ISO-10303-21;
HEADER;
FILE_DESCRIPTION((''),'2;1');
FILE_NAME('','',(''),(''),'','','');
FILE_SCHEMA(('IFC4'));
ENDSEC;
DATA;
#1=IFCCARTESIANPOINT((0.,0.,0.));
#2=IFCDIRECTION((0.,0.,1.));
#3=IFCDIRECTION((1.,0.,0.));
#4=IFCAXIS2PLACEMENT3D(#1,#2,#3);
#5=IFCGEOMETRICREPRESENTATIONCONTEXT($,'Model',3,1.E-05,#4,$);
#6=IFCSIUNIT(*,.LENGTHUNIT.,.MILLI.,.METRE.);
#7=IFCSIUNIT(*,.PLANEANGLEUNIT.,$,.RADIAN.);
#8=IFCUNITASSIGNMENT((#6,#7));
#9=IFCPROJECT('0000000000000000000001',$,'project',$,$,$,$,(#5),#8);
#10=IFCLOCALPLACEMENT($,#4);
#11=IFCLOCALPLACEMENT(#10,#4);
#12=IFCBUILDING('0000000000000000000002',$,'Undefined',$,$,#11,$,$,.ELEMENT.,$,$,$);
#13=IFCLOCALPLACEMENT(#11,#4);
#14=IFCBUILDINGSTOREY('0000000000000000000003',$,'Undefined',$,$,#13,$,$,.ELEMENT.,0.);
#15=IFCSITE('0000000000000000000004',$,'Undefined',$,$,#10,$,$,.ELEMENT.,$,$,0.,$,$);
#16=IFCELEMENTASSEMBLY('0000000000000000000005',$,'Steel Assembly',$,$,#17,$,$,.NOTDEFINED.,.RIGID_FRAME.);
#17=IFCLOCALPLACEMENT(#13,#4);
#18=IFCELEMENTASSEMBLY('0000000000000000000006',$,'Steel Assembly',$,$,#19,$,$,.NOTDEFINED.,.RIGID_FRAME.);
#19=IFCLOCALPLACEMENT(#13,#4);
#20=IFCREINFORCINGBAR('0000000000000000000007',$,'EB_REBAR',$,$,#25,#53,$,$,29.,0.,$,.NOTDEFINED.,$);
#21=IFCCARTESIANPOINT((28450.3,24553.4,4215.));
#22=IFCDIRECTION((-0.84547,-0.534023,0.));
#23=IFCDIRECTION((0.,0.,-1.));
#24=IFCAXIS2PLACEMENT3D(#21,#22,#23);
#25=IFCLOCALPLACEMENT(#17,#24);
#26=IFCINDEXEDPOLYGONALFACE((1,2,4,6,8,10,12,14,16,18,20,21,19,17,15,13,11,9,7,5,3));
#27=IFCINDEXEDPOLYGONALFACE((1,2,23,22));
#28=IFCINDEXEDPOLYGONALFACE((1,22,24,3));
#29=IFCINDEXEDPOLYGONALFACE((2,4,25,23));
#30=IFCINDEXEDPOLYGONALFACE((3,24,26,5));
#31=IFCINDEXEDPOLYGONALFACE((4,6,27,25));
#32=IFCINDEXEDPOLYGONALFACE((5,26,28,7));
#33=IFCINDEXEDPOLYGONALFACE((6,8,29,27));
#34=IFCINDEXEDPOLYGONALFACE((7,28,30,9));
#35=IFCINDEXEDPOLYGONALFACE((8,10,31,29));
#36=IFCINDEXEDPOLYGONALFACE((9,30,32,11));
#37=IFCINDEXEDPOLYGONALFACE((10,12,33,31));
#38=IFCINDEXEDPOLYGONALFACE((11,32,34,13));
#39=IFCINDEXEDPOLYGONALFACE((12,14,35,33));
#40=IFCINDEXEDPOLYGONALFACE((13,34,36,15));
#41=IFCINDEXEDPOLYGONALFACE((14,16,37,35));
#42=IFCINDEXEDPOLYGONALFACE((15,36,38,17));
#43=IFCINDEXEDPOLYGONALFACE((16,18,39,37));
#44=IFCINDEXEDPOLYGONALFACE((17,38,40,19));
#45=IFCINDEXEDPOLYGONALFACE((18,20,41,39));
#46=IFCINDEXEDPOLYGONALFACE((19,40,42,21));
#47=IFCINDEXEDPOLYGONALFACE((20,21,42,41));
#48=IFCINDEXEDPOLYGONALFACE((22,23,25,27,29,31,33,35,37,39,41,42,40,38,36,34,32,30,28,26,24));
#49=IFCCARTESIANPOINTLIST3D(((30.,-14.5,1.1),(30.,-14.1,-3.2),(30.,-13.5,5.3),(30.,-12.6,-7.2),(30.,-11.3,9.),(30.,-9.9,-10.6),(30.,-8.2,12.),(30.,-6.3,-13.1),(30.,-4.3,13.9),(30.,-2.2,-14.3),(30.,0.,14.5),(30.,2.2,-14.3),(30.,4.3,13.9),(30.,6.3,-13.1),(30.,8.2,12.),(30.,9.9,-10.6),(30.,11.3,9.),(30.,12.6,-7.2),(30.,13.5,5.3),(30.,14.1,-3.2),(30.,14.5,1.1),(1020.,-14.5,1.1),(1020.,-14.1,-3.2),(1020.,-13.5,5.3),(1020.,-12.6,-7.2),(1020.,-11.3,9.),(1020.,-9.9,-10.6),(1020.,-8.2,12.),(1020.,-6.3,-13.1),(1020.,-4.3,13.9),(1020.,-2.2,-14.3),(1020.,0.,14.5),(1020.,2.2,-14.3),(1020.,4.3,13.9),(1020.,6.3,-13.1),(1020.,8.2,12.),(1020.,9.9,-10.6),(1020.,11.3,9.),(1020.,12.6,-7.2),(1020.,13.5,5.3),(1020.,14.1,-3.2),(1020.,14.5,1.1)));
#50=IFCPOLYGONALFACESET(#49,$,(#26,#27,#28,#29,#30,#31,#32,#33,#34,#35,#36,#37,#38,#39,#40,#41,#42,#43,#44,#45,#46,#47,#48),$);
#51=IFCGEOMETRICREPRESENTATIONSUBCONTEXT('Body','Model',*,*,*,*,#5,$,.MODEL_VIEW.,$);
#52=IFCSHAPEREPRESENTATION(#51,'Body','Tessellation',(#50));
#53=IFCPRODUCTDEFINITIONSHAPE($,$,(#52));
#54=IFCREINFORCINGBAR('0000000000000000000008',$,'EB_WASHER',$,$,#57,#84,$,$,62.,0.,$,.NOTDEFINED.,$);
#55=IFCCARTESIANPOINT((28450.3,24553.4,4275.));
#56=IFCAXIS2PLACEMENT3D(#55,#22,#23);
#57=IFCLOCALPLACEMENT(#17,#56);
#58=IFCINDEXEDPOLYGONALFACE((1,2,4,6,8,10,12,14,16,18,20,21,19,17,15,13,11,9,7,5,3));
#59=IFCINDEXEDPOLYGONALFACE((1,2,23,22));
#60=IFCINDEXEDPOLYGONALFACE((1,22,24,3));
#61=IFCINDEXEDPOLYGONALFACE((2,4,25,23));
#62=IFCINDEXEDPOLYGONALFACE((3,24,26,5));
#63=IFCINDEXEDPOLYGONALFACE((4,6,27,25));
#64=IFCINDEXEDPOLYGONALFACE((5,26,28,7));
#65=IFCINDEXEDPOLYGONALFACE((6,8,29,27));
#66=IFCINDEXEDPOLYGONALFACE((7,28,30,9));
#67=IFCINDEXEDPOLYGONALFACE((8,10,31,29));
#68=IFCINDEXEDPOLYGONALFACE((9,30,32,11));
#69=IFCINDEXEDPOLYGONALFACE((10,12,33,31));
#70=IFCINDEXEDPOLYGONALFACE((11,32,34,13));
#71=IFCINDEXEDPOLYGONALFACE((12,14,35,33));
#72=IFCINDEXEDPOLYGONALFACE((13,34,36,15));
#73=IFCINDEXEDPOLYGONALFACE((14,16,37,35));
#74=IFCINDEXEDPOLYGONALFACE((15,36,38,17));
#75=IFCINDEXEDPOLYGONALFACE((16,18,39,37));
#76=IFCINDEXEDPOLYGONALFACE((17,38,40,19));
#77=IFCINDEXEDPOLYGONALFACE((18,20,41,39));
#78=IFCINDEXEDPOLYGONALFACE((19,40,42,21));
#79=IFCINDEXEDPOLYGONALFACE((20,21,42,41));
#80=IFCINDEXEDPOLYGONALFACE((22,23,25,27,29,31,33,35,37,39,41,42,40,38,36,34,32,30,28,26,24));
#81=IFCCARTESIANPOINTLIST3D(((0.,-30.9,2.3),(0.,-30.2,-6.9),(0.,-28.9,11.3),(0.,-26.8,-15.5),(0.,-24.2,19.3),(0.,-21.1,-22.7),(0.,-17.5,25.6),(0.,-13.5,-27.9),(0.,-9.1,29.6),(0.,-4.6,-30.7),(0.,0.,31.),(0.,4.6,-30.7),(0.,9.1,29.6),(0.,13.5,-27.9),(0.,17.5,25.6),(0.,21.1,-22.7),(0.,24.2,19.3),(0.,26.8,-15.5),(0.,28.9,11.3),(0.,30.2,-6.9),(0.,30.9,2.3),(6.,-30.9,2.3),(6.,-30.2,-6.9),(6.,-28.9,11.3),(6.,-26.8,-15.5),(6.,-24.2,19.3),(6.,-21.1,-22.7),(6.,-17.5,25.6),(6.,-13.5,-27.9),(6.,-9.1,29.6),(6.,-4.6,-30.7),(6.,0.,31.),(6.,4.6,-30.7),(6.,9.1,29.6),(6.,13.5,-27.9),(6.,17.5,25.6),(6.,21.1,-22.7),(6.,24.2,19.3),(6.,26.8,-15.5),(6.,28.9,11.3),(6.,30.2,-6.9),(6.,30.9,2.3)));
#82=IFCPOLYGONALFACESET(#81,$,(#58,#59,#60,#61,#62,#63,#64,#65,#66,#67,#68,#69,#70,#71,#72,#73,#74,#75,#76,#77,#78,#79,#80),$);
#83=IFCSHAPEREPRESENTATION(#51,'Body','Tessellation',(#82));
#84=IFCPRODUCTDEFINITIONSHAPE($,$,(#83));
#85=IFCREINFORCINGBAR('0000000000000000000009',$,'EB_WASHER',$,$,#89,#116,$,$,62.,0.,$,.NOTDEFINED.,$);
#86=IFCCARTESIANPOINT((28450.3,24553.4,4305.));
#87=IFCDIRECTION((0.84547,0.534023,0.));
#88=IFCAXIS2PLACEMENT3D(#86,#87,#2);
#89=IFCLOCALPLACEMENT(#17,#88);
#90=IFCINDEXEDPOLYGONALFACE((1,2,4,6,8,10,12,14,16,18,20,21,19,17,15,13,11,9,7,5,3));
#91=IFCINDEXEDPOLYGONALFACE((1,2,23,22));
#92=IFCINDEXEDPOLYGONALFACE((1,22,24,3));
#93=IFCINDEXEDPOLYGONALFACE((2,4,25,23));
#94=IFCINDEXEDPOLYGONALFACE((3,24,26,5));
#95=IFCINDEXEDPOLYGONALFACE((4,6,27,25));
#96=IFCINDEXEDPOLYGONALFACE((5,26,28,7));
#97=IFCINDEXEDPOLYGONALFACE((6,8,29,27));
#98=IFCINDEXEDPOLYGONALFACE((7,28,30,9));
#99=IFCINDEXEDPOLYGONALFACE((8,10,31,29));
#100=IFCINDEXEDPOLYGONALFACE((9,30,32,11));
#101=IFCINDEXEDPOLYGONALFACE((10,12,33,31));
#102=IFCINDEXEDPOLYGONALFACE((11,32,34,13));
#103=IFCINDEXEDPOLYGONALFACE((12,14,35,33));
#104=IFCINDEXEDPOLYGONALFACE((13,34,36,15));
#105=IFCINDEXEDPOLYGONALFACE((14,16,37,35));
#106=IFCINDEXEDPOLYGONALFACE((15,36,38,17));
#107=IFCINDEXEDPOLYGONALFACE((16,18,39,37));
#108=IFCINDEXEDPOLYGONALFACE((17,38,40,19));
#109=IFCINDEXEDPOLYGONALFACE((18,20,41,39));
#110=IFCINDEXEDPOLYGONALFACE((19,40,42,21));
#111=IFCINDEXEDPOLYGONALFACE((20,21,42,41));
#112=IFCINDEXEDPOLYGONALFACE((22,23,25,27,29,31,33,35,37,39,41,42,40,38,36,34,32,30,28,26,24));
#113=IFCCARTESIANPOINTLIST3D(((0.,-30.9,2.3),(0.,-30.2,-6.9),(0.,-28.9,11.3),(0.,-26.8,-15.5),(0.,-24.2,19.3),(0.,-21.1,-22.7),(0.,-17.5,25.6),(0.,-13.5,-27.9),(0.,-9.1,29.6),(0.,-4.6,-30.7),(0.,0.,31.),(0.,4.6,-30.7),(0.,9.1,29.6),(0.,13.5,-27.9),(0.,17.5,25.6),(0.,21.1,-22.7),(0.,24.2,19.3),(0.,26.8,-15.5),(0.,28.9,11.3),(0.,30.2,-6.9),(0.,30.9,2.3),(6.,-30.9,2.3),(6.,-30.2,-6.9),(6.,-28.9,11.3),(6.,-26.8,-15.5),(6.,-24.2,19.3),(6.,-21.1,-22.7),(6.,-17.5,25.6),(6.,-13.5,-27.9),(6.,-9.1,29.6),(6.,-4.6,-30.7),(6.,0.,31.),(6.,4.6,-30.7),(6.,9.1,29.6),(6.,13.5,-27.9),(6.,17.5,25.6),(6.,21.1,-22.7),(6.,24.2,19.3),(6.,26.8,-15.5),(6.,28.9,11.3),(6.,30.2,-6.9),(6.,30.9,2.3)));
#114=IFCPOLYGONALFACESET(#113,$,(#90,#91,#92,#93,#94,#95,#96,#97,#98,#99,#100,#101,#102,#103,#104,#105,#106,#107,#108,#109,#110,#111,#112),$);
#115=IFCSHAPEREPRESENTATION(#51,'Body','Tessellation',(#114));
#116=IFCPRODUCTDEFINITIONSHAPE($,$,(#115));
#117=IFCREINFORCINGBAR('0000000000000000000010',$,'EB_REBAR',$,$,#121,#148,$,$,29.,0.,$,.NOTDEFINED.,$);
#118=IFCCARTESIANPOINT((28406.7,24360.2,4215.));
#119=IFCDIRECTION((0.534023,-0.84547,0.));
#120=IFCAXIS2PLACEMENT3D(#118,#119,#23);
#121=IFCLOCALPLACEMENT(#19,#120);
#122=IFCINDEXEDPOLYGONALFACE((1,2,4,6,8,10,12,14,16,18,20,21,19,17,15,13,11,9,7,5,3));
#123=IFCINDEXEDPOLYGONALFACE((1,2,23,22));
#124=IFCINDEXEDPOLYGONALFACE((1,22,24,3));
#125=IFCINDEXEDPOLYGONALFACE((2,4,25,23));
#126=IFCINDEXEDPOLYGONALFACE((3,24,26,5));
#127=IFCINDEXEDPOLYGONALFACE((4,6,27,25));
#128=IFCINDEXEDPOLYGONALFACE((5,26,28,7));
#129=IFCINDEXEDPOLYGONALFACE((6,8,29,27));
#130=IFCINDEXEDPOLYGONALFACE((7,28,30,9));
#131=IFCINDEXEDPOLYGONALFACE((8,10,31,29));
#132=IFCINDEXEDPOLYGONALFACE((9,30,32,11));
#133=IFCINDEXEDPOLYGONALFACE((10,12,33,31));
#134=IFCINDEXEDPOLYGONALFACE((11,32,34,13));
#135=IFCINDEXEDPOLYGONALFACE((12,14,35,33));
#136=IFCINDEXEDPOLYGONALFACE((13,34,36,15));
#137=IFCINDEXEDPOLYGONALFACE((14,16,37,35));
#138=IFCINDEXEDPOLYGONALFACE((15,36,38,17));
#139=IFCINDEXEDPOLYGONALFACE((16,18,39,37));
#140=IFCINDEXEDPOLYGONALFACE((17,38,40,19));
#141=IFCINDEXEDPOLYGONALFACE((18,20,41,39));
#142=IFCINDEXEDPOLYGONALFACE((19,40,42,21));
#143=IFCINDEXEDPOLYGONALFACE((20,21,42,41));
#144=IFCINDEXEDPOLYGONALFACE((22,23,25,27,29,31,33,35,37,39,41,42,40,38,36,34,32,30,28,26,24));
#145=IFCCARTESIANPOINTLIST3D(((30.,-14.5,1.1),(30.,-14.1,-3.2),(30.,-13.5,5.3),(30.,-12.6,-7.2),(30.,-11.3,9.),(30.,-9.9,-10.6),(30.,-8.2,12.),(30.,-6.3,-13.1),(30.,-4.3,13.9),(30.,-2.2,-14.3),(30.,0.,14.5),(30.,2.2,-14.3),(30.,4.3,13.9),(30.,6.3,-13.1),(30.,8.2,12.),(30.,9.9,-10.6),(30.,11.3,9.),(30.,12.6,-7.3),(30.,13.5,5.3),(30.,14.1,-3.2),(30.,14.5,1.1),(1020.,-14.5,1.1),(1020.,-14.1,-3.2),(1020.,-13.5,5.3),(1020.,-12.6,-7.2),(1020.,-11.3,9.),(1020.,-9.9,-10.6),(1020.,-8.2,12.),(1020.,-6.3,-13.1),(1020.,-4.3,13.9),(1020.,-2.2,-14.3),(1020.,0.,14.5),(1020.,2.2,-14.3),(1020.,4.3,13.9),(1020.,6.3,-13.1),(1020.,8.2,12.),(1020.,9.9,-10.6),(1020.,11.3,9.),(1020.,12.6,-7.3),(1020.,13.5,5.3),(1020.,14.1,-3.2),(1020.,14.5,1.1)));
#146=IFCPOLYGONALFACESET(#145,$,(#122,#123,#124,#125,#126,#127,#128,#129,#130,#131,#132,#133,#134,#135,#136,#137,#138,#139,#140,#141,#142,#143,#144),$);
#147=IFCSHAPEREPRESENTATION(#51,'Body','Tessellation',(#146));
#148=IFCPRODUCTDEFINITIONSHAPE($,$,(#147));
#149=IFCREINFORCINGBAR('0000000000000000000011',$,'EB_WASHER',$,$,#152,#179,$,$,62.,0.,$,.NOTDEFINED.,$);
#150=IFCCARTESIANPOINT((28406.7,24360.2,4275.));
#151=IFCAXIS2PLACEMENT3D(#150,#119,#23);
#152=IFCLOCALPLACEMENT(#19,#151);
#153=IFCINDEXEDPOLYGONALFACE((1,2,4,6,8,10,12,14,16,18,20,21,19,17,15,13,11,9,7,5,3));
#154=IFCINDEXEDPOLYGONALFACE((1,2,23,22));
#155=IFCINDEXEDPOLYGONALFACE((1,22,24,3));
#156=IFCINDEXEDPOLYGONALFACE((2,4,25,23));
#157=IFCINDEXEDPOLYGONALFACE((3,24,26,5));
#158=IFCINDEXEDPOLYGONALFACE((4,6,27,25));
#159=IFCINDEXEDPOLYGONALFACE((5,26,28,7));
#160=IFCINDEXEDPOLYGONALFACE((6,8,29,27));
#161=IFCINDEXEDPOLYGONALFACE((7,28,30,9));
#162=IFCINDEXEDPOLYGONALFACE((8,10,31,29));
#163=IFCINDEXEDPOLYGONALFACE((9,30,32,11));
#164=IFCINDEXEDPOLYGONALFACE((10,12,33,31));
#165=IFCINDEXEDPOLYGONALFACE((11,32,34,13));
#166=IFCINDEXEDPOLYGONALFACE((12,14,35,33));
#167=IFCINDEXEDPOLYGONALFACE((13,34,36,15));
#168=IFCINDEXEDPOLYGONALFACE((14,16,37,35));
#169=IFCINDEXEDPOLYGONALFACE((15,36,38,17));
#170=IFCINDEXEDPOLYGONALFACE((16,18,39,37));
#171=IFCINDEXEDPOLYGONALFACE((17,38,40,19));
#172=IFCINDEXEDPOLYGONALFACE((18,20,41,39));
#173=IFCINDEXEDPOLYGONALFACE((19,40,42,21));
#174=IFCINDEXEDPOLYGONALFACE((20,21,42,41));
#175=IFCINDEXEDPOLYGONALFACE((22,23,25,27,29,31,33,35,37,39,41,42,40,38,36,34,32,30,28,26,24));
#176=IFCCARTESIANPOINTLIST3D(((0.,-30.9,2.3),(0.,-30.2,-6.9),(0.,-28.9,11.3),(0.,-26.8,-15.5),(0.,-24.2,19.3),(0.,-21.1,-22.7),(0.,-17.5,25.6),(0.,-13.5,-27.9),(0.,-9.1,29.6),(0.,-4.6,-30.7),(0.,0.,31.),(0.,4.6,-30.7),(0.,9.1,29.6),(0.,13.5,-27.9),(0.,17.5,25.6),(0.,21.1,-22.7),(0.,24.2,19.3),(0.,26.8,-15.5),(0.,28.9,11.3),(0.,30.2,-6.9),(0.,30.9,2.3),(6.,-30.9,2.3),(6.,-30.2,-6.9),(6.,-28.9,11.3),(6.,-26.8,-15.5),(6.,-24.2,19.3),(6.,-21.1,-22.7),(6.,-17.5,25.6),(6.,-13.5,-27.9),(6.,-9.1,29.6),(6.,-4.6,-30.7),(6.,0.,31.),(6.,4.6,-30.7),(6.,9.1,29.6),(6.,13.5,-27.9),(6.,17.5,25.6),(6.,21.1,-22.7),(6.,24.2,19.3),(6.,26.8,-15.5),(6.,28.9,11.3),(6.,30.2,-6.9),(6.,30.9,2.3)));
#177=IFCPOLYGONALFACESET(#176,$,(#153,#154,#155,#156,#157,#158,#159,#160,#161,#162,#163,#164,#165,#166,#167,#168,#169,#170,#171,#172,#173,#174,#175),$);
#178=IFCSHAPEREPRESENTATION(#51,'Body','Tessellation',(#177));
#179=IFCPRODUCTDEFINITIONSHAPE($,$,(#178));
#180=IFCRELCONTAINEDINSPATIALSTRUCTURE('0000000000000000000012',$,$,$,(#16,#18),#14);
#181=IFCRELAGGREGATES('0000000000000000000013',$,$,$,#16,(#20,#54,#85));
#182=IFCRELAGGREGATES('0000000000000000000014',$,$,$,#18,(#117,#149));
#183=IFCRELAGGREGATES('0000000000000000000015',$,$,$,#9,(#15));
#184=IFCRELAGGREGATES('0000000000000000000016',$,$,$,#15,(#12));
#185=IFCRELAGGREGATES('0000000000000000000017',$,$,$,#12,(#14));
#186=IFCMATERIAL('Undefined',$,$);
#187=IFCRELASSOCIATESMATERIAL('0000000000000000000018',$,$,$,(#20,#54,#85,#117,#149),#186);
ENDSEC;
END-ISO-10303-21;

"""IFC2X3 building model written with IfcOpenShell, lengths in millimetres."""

from ifc_helpers import new_model, entity, si_unit, frame, origin_with_axes, place, context, subcontext, project, spatial, source, transform, mapped, material, element, aggregate, save


model = new_model("IFC2X3")

# Units and contexts
model_context = context("Model", 3, precision=1e-05, world=origin_with_axes())
body_context = subcontext(model_context, "Body", "Model", "MODEL_VIEW")
ifc_project = project(units=[si_unit("LENGTHUNIT", "METRE", prefix="MILLI"), si_unit("PLANEANGLEUNIT", "RADIAN")], contexts=[model_context])

# Site, building, storey
site_placement = place(None, origin_with_axes())
site = spatial("IfcSite", under=ifc_project, at=site_placement, Name="Undefined", CompositionType="ELEMENT", RefElevation=0.0)
building_placement = place(site_placement, origin_with_axes())
building = spatial("IfcBuilding", under=site, at=building_placement, Name="Undefined", CompositionType="ELEMENT")
storey_placement = place(building_placement, origin_with_axes())
storey = spatial("IfcBuildingStorey", under=building, at=storey_placement, Name="Undefined", CompositionType="ELEMENT", Elevation=0.0)

# Element assemblies
assembly_1_placement = place(storey_placement, origin_with_axes())
assembly_1 = element("IfcElementAssembly", 1, at=assembly_1_placement, inside=storey, Name="Steel Assembly", AssemblyPlace="NOTDEFINED", PredefinedType="RIGID_FRAME")
assembly_2_placement = place(storey_placement, origin_with_axes())
assembly_2 = element("IfcElementAssembly", 2, at=assembly_2_placement, inside=storey, Name="Steel Assembly", AssemblyPlace="NOTDEFINED", PredefinedType="RIGID_FRAME")

# Shared definitions
ifc_material_1 = material(Name="Undefined")

# Reinforcing bars
shared_shape_1 = source(origin_with_axes(), body_context, "Body", "AdvancedSweptSolid", [
    entity("IfcSweptDiskSolid", entity("IfcTrimmedCurve", entity("IfcLine", entity("IfcCartesianPoint", [0.0, 0.0, 0.0]), entity("IfcVector", entity("IfcDirection", [1.0, 0.0, 0.0]), 1.0)), [entity("IfcParameterValue", 0.0)], [entity("IfcParameterValue", 990.0)], True, "PARAMETER"), 14.5, None, 0.0, 990.0),
])
reinforcing_bar_1_placement = place(assembly_1_placement, frame((28450.3, 24553.4, 4215.0), z_axis=(-0.84547, -0.534023, 0.0), x_axis=(0.0, 0.0, -1.0)))
reinforcing_bar_1 = element("IfcReinforcingBar", 3, at=reinforcing_bar_1_placement, material=ifc_material_1, Name="EB_REBAR", BarRole="NOTDEFINED", CrossSectionArea=0.0, NominalDiameter=29.0, context=body_context, shape_type="MappedRepresentation", body=[
    mapped(shared_shape_1, transform((30.0, 0.0, 0.0))),
])
shared_shape_2 = source(origin_with_axes(), body_context, "Body", "AdvancedSweptSolid", [
    entity("IfcSweptDiskSolid", entity("IfcTrimmedCurve", entity("IfcLine", entity("IfcCartesianPoint", [0.0, 0.0, 0.0]), entity("IfcVector", entity("IfcDirection", [1.0, 0.0, 0.0]), 1.0)), [entity("IfcParameterValue", 0.0)], [entity("IfcParameterValue", 6.0)], True, "PARAMETER"), 31.0, None, 0.0, 6.0),
])
reinforcing_bar_2_placement = place(assembly_1_placement, frame((28450.3, 24553.4, 4275.0), z_axis=(-0.84547, -0.534023, 0.0), x_axis=(0.0, 0.0, -1.0)))
reinforcing_bar_2 = element("IfcReinforcingBar", 4, at=reinforcing_bar_2_placement, material=ifc_material_1, Name="EB_WASHER", BarRole="NOTDEFINED", CrossSectionArea=0.0, NominalDiameter=62.0, context=body_context, shape_type="MappedRepresentation", body=[
    mapped(shared_shape_2, transform((0.0, 0.0, 0.0))),
])
shared_shape_3 = source(origin_with_axes(), body_context, "Body", "AdvancedSweptSolid", [
    entity("IfcSweptDiskSolid", entity("IfcTrimmedCurve", entity("IfcLine", entity("IfcCartesianPoint", [0.0, 0.0, 0.0]), entity("IfcVector", entity("IfcDirection", [1.0, 0.0, 0.0]), 1.0)), [entity("IfcParameterValue", 0.0)], [entity("IfcParameterValue", 6.0)], True, "PARAMETER"), 31.0, None, 0.0, 6.0),
])
reinforcing_bar_3_placement = place(assembly_1_placement, frame((28450.3, 24553.4, 4305.0), z_axis=(0.84547, 0.534023, 0.0), x_axis=(0.0, 0.0, 1.0)))
reinforcing_bar_3 = element("IfcReinforcingBar", 5, at=reinforcing_bar_3_placement, material=ifc_material_1, Name="EB_WASHER", BarRole="NOTDEFINED", CrossSectionArea=0.0, NominalDiameter=62.0, context=body_context, shape_type="MappedRepresentation", body=[
    mapped(shared_shape_3, transform((0.0, 0.0, 0.0))),
])
aggregate(assembly_1, [reinforcing_bar_1, reinforcing_bar_2, reinforcing_bar_3])
shared_shape_4 = source(origin_with_axes(), body_context, "Body", "AdvancedSweptSolid", [
    entity("IfcSweptDiskSolid", entity("IfcTrimmedCurve", entity("IfcLine", entity("IfcCartesianPoint", [0.0, 0.0, 0.0]), entity("IfcVector", entity("IfcDirection", [1.0, 0.0, 0.0]), 1.0)), [entity("IfcParameterValue", 0.0)], [entity("IfcParameterValue", 990.0)], True, "PARAMETER"), 14.5, None, 0.0, 990.0),
])
reinforcing_bar_4_placement = place(assembly_2_placement, frame((28406.7, 24360.2, 4215.0), z_axis=(0.534023, -0.84547, 0.0), x_axis=(0.0, 0.0, -1.0)))
reinforcing_bar_4 = element("IfcReinforcingBar", 6, at=reinforcing_bar_4_placement, material=ifc_material_1, Name="EB_REBAR", BarRole="NOTDEFINED", CrossSectionArea=0.0, NominalDiameter=29.0, context=body_context, shape_type="MappedRepresentation", body=[
    mapped(shared_shape_4, transform((30.0, 0.0, 0.0))),
])
shared_shape_5 = source(origin_with_axes(), body_context, "Body", "AdvancedSweptSolid", [
    entity("IfcSweptDiskSolid", entity("IfcTrimmedCurve", entity("IfcLine", entity("IfcCartesianPoint", [0.0, 0.0, 0.0]), entity("IfcVector", entity("IfcDirection", [1.0, 0.0, 0.0]), 1.0)), [entity("IfcParameterValue", 0.0)], [entity("IfcParameterValue", 6.0)], True, "PARAMETER"), 31.0, None, 0.0, 6.0),
])
reinforcing_bar_5_placement = place(assembly_2_placement, frame((28406.7, 24360.2, 4275.0), z_axis=(0.534023, -0.84547, 0.0), x_axis=(0.0, 0.0, -1.0)))
reinforcing_bar_5 = element("IfcReinforcingBar", 7, at=reinforcing_bar_5_placement, material=ifc_material_1, Name="EB_WASHER", BarRole="NOTDEFINED", CrossSectionArea=0.0, NominalDiameter=62.0, context=body_context, shape_type="MappedRepresentation", body=[
    mapped(shared_shape_5, transform((0.0, 0.0, 0.0))),
])
aggregate(assembly_2, [reinforcing_bar_4, reinforcing_bar_5])

save(model, "model.ifc")
